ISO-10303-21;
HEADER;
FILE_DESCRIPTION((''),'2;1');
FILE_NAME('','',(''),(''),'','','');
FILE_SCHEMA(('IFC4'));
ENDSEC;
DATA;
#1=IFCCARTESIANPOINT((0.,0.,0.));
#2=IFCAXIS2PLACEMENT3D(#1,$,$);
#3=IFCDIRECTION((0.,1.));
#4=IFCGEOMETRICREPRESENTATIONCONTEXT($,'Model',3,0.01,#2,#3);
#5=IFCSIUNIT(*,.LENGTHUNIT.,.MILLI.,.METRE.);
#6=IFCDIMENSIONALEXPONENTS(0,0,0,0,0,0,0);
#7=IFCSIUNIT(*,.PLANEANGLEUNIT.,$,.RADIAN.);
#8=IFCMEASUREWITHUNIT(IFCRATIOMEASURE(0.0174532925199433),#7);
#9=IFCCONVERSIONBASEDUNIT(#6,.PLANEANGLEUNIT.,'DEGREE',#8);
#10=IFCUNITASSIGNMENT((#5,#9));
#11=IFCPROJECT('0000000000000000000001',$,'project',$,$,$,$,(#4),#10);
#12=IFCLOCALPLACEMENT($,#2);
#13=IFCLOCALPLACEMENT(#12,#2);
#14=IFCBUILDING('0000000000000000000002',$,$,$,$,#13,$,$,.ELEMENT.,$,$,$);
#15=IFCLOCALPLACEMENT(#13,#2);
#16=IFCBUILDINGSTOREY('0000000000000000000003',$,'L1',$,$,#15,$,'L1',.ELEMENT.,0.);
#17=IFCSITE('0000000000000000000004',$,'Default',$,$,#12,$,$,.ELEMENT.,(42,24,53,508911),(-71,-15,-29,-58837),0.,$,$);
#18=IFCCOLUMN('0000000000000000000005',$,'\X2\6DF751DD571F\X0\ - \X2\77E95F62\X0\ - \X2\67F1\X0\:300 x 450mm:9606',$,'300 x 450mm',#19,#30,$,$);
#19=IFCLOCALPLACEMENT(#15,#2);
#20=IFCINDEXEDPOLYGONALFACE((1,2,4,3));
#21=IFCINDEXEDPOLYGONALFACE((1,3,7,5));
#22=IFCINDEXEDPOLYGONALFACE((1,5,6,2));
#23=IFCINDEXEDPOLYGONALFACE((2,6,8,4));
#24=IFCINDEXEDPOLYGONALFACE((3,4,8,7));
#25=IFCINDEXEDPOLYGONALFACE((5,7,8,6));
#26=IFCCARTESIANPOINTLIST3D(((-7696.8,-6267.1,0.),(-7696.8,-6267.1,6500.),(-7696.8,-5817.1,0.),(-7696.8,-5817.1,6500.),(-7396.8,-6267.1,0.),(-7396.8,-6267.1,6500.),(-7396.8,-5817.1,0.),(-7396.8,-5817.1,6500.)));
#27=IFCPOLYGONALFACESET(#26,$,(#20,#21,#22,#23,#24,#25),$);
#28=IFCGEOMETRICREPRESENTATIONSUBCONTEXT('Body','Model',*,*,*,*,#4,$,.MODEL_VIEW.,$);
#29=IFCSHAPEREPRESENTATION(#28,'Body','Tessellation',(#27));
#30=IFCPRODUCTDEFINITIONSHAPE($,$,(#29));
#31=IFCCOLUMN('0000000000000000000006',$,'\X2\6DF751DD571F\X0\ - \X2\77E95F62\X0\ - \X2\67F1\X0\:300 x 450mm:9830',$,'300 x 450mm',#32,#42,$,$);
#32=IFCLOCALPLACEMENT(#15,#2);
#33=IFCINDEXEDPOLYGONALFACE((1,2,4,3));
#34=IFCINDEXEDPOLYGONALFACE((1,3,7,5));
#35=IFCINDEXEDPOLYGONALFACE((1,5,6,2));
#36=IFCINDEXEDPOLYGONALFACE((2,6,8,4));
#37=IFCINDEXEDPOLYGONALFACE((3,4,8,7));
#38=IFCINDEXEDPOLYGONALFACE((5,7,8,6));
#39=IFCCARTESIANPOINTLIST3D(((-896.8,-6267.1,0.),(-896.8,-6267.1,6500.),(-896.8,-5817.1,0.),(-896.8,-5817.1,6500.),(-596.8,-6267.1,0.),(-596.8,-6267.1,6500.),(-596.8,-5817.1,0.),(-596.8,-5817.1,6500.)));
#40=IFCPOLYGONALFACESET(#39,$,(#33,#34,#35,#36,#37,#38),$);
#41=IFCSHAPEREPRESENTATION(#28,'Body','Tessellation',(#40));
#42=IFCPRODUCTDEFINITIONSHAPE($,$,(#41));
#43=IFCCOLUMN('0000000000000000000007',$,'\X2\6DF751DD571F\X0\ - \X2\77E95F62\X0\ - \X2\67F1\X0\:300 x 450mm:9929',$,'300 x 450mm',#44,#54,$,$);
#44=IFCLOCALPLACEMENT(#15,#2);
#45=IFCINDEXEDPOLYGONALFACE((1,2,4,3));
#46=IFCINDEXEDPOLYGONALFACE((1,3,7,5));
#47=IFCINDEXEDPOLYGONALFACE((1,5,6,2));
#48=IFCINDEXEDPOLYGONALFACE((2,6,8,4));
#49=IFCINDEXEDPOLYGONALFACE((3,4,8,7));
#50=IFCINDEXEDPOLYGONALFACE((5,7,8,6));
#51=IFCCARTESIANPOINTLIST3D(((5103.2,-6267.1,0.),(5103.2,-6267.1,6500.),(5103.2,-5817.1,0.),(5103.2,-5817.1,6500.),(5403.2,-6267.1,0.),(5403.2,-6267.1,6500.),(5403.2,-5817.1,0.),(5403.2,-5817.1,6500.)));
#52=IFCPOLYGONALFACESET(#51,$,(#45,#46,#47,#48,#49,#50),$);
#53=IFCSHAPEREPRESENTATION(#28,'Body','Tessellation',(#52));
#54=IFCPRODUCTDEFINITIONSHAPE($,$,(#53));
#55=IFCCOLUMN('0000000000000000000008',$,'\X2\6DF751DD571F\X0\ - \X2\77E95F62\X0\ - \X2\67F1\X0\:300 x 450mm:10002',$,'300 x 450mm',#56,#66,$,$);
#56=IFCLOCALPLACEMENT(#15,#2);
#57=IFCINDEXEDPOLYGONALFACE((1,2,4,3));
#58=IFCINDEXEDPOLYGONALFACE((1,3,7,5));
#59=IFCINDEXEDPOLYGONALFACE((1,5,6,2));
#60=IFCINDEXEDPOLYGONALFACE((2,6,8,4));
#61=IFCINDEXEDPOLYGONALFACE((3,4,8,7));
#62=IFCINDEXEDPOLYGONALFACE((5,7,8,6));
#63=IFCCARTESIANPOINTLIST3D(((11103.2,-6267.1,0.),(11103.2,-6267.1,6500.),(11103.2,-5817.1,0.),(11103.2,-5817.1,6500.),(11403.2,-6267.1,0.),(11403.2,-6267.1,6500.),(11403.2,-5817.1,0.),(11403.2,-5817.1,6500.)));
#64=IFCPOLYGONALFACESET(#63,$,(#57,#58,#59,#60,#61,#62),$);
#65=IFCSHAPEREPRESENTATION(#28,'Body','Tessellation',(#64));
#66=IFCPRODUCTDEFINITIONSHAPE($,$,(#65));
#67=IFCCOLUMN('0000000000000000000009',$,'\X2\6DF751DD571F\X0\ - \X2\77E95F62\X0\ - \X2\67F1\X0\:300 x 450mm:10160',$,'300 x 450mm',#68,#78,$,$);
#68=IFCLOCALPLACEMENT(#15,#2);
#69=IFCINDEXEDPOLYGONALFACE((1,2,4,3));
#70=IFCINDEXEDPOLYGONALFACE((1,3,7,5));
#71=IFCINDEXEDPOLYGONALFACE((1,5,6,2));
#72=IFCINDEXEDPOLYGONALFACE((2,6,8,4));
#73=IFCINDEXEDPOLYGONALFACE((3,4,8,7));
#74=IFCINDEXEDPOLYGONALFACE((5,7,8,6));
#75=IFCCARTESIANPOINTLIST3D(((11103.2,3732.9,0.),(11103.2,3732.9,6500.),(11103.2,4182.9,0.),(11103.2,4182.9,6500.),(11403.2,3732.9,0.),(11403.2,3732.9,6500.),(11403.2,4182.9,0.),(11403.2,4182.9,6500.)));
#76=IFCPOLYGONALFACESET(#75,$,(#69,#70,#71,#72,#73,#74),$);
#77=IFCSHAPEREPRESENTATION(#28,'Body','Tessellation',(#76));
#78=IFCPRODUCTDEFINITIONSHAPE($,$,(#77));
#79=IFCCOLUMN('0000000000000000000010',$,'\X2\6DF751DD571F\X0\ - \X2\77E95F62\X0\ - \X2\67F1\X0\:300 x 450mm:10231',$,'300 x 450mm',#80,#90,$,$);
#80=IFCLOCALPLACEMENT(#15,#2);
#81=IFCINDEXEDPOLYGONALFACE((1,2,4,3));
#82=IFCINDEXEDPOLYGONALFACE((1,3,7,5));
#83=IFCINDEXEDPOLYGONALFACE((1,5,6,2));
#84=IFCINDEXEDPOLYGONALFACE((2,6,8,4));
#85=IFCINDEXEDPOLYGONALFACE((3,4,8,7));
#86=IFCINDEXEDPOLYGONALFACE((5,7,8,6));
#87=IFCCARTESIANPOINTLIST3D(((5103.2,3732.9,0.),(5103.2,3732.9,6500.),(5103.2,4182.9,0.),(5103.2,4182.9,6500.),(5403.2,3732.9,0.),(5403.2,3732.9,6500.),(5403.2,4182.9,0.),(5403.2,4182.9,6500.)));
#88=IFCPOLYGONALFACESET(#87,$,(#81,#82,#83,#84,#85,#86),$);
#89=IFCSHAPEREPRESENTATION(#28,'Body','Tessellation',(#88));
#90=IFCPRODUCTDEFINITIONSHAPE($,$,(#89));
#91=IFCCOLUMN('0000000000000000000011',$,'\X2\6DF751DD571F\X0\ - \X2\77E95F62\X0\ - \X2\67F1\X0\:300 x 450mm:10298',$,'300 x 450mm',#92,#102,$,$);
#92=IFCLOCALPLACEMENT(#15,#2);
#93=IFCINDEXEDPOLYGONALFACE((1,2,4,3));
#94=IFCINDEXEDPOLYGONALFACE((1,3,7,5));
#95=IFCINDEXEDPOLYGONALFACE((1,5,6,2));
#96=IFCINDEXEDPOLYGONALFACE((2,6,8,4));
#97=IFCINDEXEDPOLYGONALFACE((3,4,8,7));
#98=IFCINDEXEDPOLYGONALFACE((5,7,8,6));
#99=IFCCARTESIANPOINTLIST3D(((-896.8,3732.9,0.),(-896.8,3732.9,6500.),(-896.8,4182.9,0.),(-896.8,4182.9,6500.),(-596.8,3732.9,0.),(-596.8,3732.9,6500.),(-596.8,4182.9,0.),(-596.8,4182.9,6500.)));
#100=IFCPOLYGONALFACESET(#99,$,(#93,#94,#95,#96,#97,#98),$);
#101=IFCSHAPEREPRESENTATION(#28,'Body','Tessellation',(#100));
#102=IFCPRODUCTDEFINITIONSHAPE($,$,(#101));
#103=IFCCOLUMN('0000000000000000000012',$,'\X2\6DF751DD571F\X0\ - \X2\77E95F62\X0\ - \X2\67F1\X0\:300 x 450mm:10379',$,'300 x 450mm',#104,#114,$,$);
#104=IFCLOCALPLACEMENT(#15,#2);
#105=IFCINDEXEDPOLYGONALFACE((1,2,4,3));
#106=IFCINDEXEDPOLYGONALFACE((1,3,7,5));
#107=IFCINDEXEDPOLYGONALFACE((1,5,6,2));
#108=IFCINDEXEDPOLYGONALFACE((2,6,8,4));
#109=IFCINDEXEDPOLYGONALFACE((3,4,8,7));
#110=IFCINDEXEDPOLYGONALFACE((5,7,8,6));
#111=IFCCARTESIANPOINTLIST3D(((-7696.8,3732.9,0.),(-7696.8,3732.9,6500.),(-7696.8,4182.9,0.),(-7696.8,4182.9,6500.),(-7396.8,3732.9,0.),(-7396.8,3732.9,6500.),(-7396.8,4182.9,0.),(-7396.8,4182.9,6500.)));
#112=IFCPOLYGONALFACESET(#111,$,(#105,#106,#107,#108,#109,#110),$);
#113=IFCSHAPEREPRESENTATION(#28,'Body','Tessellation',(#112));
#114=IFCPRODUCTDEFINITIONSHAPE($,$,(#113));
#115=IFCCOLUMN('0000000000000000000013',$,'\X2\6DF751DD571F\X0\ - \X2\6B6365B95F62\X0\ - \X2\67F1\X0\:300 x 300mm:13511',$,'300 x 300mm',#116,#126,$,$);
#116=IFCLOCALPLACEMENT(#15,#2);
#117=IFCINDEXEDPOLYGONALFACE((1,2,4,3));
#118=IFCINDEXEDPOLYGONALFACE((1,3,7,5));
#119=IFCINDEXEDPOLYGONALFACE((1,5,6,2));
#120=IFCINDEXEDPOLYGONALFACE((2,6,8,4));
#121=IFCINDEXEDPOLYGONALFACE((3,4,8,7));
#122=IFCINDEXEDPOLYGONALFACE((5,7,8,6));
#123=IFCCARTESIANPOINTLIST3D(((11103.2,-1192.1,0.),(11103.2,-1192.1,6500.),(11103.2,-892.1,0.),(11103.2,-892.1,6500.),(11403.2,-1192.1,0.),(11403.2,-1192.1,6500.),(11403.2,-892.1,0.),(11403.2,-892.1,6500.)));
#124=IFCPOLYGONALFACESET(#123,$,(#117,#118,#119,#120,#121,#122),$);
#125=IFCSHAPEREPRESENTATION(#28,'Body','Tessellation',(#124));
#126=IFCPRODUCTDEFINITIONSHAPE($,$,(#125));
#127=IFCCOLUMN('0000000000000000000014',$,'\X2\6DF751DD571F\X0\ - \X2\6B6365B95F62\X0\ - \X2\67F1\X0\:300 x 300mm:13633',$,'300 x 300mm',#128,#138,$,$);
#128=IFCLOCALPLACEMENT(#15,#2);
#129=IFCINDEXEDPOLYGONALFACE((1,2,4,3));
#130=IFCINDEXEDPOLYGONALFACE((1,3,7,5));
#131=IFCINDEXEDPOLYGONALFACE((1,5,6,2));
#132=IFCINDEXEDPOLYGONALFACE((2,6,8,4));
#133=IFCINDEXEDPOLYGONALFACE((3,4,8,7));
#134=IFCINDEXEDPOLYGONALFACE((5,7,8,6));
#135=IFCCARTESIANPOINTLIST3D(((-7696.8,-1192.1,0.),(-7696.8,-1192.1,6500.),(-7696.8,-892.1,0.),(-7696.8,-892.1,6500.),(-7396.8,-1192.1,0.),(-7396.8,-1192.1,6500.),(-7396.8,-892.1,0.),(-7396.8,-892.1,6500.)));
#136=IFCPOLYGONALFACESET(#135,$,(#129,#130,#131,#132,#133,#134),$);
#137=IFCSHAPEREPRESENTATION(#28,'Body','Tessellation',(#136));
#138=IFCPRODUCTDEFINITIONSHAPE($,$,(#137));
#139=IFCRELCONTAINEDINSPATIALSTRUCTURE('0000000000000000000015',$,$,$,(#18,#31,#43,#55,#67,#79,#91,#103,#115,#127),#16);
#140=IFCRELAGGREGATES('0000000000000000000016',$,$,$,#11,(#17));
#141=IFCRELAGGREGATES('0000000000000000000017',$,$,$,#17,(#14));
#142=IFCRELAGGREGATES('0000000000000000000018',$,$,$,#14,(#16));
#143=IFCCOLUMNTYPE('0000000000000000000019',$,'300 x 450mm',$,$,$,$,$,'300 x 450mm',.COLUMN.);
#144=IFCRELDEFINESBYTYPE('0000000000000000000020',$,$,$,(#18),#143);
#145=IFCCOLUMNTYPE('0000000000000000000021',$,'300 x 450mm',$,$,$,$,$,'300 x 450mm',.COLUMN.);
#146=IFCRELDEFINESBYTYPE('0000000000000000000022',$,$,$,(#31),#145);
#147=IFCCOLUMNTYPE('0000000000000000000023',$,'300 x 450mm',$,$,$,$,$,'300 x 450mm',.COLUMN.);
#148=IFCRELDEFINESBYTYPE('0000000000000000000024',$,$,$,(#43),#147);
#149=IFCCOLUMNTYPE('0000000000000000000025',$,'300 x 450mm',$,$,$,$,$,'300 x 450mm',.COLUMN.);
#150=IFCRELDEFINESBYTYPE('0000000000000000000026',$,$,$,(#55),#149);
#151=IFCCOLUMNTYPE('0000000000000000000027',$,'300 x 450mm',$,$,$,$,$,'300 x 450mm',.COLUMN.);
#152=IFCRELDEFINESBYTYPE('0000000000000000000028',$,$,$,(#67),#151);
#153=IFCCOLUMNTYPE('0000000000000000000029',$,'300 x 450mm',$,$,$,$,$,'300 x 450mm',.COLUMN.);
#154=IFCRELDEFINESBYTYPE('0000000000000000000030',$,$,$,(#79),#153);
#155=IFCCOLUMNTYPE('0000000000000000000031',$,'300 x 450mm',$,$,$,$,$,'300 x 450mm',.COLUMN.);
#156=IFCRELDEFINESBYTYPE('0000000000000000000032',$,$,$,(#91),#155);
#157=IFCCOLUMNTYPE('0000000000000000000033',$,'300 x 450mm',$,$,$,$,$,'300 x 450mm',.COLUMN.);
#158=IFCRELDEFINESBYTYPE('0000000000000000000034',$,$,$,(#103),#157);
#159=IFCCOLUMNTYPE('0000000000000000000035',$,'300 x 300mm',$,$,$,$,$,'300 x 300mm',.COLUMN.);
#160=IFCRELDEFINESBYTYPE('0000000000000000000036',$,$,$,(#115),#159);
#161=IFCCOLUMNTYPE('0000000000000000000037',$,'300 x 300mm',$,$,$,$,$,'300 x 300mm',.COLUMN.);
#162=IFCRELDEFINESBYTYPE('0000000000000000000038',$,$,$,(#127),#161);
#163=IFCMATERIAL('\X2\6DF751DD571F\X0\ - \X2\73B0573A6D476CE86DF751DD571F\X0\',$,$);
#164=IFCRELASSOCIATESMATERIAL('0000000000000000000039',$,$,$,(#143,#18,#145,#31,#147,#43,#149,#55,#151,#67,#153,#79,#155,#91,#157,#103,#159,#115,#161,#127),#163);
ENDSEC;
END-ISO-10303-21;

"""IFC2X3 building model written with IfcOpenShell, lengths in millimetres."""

from ifc_helpers import new_model, entity, si_unit, converted_unit, direction, frame, frame_2d, origin, origin_2d_with_axis, place, context, subcontext, project, spatial, rectangle, extrude, source, transform, mapped, material, type_object, type_shapes, element, save


model = new_model("IFC2X3")

# Units and contexts
model_context = context("Model", 3, precision=0.01, world=origin(), true_north=direction((0.0, 1.0)))
body_context = subcontext(model_context, "Body", "Model", "MODEL_VIEW")
ifc_project = project(units=[si_unit("LENGTHUNIT", "METRE", prefix="MILLI"), converted_unit("PLANEANGLEUNIT", "DEGREE", entity("IfcRatioMeasure", 0.0174532925199433), si_unit("PLANEANGLEUNIT", "RADIAN"), dimensions=[0, 0, 0, 0, 0, 0, 0])], contexts=[model_context])

# Site, building, storey
site_placement = place(None, origin())
site = spatial("IfcSite", under=ifc_project, at=site_placement, Name="Default", CompositionType="ELEMENT", RefLatitude=(42, 24, 53, 508911), RefLongitude=(-71, -15, -29, -58837), RefElevation=0.0)
building_placement = place(site_placement, origin())
building = spatial("IfcBuilding", under=site, at=building_placement, CompositionType="ELEMENT")
storey_placement = place(building_placement, origin())
storey = spatial("IfcBuildingStorey", under=building, at=storey_placement, Name="L1", LongName="L1", CompositionType="ELEMENT", Elevation=0.0)

# Columns
ifc_material = material(Name="混凝土 - 现场浇注混凝土")
column_type_1 = type_object("IfcColumnType", Name="300 x 450mm", ElementType="300 x 450mm", PredefinedType="COLUMN", material=ifc_material)
shared_shape_1 = source(origin(), body_context, "Body", "SweptSolid", [
    extrude(rectangle(XDim=450.0, YDim=300.0, at=frame_2d((0.0, 0.0), x_axis=(1.0, 0.0))), frame((-7546.8, -6042.1, 0.0), z_axis=(0.0, 0.0, 1.0), x_axis=(0.0, -1.0, 0.0)), (0.0, 0.0, 1.0), 6500.0),
])
type_shapes(column_type_1, [shared_shape_1])
column_1_placement = place(storey_placement, origin())
element("IfcColumn", 1, at=column_1_placement, inside=storey, type_object=column_type_1, material=ifc_material, Name="混凝土 - 矩形 - 柱:300 x 450mm:9606", ObjectType="300 x 450mm", context=body_context, shape_type="MappedRepresentation", body=[
    mapped(shared_shape_1, transform((0.0, 0.0, 0.0), scale=1.0)),
])
column_type_2 = type_object("IfcColumnType", Name="300 x 450mm", ElementType="300 x 450mm", PredefinedType="COLUMN", material=ifc_material)
shared_shape_2 = source(origin(), body_context, "Body", "SweptSolid", [
    extrude(rectangle(XDim=450.0, YDim=300.0, at=origin_2d_with_axis()), frame((-746.8, -6042.1, 0.0), z_axis=(0.0, 0.0, 1.0), x_axis=(0.0, -1.0, 0.0)), (0.0, 0.0, 1.0), 6500.0),
])
type_shapes(column_type_2, [shared_shape_2])
column_2_placement = place(storey_placement, origin())
element("IfcColumn", 2, at=column_2_placement, inside=storey, type_object=column_type_2, material=ifc_material, Name="混凝土 - 矩形 - 柱:300 x 450mm:9830", ObjectType="300 x 450mm", context=body_context, shape_type="MappedRepresentation", body=[
    mapped(shared_shape_2, transform((0.0, 0.0, 0.0), scale=1.0)),
])
column_type_3 = type_object("IfcColumnType", Name="300 x 450mm", ElementType="300 x 450mm", PredefinedType="COLUMN", material=ifc_material)
shared_shape_3 = source(origin(), body_context, "Body", "SweptSolid", [
    extrude(rectangle(XDim=450.0, YDim=300.0, at=frame_2d((0.0, 0.0), x_axis=(1.0, 0.0))), frame((5253.2, -6042.1, 0.0), z_axis=(0.0, 0.0, 1.0), x_axis=(0.0, -1.0, 0.0)), (0.0, 0.0, 1.0), 6500.0),
])
type_shapes(column_type_3, [shared_shape_3])
column_3_placement = place(storey_placement, origin())
element("IfcColumn", 3, at=column_3_placement, inside=storey, type_object=column_type_3, material=ifc_material, Name="混凝土 - 矩形 - 柱:300 x 450mm:9929", ObjectType="300 x 450mm", context=body_context, shape_type="MappedRepresentation", body=[
    mapped(shared_shape_3, transform((0.0, 0.0, 0.0), scale=1.0)),
])
column_type_4 = type_object("IfcColumnType", Name="300 x 450mm", ElementType="300 x 450mm", PredefinedType="COLUMN", material=ifc_material)
shared_shape_4 = source(origin(), body_context, "Body", "SweptSolid", [
    extrude(rectangle(XDim=450.0, YDim=300.0, at=origin_2d_with_axis()), frame((11253.2, -6042.1, 0.0), z_axis=(0.0, 0.0, 1.0), x_axis=(0.0, -1.0, 0.0)), (0.0, 0.0, 1.0), 6500.0),
])
type_shapes(column_type_4, [shared_shape_4])
column_4_placement = place(storey_placement, origin())
element("IfcColumn", 4, at=column_4_placement, inside=storey, type_object=column_type_4, material=ifc_material, Name="混凝土 - 矩形 - 柱:300 x 450mm:10002", ObjectType="300 x 450mm", context=body_context, shape_type="MappedRepresentation", body=[
    mapped(shared_shape_4, transform((0.0, 0.0, 0.0), scale=1.0)),
])
column_type_5 = type_object("IfcColumnType", Name="300 x 450mm", ElementType="300 x 450mm", PredefinedType="COLUMN", material=ifc_material)
shared_shape_5 = source(origin(), body_context, "Body", "SweptSolid", [
    extrude(rectangle(XDim=450.0, YDim=300.0, at=frame_2d((0.0, 0.0), x_axis=(1.0, 0.0))), frame((11253.2, 3957.9, 0.0), z_axis=(0.0, 0.0, 1.0), x_axis=(0.0, -1.0, 0.0)), (0.0, 0.0, 1.0), 6500.0),
])
type_shapes(column_type_5, [shared_shape_5])
column_5_placement = place(storey_placement, origin())
element("IfcColumn", 5, at=column_5_placement, inside=storey, type_object=column_type_5, material=ifc_material, Name="混凝土 - 矩形 - 柱:300 x 450mm:10160", ObjectType="300 x 450mm", context=body_context, shape_type="MappedRepresentation", body=[
    mapped(shared_shape_5, transform((0.0, 0.0, 0.0), scale=1.0)),
])
column_type_6 = type_object("IfcColumnType", Name="300 x 450mm", ElementType="300 x 450mm", PredefinedType="COLUMN", material=ifc_material)
shared_shape_6 = source(origin(), body_context, "Body", "SweptSolid", [
    extrude(rectangle(XDim=450.0, YDim=300.0, at=frame_2d((0.0, 0.0), x_axis=(1.0, 0.0))), frame((5253.2, 3957.9, 0.0), z_axis=(0.0, 0.0, 1.0), x_axis=(0.0, -1.0, 0.0)), (0.0, 0.0, 1.0), 6500.0),
])
type_shapes(column_type_6, [shared_shape_6])
column_6_placement = place(storey_placement, origin())
element("IfcColumn", 6, at=column_6_placement, inside=storey, type_object=column_type_6, material=ifc_material, Name="混凝土 - 矩形 - 柱:300 x 450mm:10231", ObjectType="300 x 450mm", context=body_context, shape_type="MappedRepresentation", body=[
    mapped(shared_shape_6, transform((0.0, 0.0, 0.0), scale=1.0)),
])
column_type_7 = type_object("IfcColumnType", Name="300 x 450mm", ElementType="300 x 450mm", PredefinedType="COLUMN", material=ifc_material)
shared_shape_7 = source(origin(), body_context, "Body", "SweptSolid", [
    extrude(rectangle(XDim=450.0, YDim=300.0, at=frame_2d((0.0, 0.0), x_axis=(1.0, 0.0))), frame((-746.8, 3957.9, 0.0), z_axis=(0.0, 0.0, 1.0), x_axis=(0.0, -1.0, 0.0)), (0.0, 0.0, 1.0), 6500.0),
])
type_shapes(column_type_7, [shared_shape_7])
column_7_placement = place(storey_placement, origin())
element("IfcColumn", 7, at=column_7_placement, inside=storey, type_object=column_type_7, material=ifc_material, Name="混凝土 - 矩形 - 柱:300 x 450mm:10298", ObjectType="300 x 450mm", context=body_context, shape_type="MappedRepresentation", body=[
    mapped(shared_shape_7, transform((0.0, 0.0, 0.0), scale=1.0)),
])
column_type_8 = type_object("IfcColumnType", Name="300 x 450mm", ElementType="300 x 450mm", PredefinedType="COLUMN", material=ifc_material)
shared_shape_8 = source(origin(), body_context, "Body", "SweptSolid", [
    extrude(rectangle(XDim=450.0, YDim=300.0, at=frame_2d((0.0, 0.0), x_axis=(1.0, 0.0))), frame((-7546.8, 3957.9, 0.0), z_axis=(0.0, 0.0, 1.0), x_axis=(0.0, -1.0, 0.0)), (0.0, 0.0, 1.0), 6500.0),
])
type_shapes(column_type_8, [shared_shape_8])
column_8_placement = place(storey_placement, origin())
element("IfcColumn", 8, at=column_8_placement, inside=storey, type_object=column_type_8, material=ifc_material, Name="混凝土 - 矩形 - 柱:300 x 450mm:10379", ObjectType="300 x 450mm", context=body_context, shape_type="MappedRepresentation", body=[
    mapped(shared_shape_8, transform((0.0, 0.0, 0.0), scale=1.0)),
])
column_type_9 = type_object("IfcColumnType", Name="300 x 300mm", ElementType="300 x 300mm", PredefinedType="COLUMN", material=ifc_material)
shared_shape_9 = source(origin(), body_context, "Body", "SweptSolid", [
    extrude(rectangle(XDim=300.0, YDim=300.0, at=origin_2d_with_axis()), frame((11253.2, -1042.1, 0.0), z_axis=(0.0, 0.0, 1.0), x_axis=(0.0, -1.0, 0.0)), (0.0, 0.0, 1.0), 6500.0),
])
type_shapes(column_type_9, [shared_shape_9])
column_9_placement = place(storey_placement, origin())
element("IfcColumn", 9, at=column_9_placement, inside=storey, type_object=column_type_9, material=ifc_material, Name="混凝土 - 正方形 - 柱:300 x 300mm:13511", ObjectType="300 x 300mm", context=body_context, shape_type="MappedRepresentation", body=[
    mapped(shared_shape_9, transform((0.0, 0.0, 0.0), scale=1.0)),
])
column_type_10 = type_object("IfcColumnType", Name="300 x 300mm", ElementType="300 x 300mm", PredefinedType="COLUMN", material=ifc_material)
shared_shape_10 = source(origin(), body_context, "Body", "SweptSolid", [
    extrude(rectangle(XDim=300.0, YDim=300.0, at=frame_2d((0.0, 0.0), x_axis=(1.0, 0.0))), frame((-7546.8, -1042.1, 0.0), z_axis=(0.0, 0.0, 1.0), x_axis=(0.0, -1.0, 0.0)), (0.0, 0.0, 1.0), 6500.0),
])
type_shapes(column_type_10, [shared_shape_10])
column_10_placement = place(storey_placement, origin())
element("IfcColumn", 10, at=column_10_placement, inside=storey, type_object=column_type_10, material=ifc_material, Name="混凝土 - 正方形 - 柱:300 x 300mm:13633", ObjectType="300 x 300mm", context=body_context, shape_type="MappedRepresentation", body=[
    mapped(shared_shape_10, transform((0.0, 0.0, 0.0), scale=1.0)),
])

save(model, "model.ifc")
